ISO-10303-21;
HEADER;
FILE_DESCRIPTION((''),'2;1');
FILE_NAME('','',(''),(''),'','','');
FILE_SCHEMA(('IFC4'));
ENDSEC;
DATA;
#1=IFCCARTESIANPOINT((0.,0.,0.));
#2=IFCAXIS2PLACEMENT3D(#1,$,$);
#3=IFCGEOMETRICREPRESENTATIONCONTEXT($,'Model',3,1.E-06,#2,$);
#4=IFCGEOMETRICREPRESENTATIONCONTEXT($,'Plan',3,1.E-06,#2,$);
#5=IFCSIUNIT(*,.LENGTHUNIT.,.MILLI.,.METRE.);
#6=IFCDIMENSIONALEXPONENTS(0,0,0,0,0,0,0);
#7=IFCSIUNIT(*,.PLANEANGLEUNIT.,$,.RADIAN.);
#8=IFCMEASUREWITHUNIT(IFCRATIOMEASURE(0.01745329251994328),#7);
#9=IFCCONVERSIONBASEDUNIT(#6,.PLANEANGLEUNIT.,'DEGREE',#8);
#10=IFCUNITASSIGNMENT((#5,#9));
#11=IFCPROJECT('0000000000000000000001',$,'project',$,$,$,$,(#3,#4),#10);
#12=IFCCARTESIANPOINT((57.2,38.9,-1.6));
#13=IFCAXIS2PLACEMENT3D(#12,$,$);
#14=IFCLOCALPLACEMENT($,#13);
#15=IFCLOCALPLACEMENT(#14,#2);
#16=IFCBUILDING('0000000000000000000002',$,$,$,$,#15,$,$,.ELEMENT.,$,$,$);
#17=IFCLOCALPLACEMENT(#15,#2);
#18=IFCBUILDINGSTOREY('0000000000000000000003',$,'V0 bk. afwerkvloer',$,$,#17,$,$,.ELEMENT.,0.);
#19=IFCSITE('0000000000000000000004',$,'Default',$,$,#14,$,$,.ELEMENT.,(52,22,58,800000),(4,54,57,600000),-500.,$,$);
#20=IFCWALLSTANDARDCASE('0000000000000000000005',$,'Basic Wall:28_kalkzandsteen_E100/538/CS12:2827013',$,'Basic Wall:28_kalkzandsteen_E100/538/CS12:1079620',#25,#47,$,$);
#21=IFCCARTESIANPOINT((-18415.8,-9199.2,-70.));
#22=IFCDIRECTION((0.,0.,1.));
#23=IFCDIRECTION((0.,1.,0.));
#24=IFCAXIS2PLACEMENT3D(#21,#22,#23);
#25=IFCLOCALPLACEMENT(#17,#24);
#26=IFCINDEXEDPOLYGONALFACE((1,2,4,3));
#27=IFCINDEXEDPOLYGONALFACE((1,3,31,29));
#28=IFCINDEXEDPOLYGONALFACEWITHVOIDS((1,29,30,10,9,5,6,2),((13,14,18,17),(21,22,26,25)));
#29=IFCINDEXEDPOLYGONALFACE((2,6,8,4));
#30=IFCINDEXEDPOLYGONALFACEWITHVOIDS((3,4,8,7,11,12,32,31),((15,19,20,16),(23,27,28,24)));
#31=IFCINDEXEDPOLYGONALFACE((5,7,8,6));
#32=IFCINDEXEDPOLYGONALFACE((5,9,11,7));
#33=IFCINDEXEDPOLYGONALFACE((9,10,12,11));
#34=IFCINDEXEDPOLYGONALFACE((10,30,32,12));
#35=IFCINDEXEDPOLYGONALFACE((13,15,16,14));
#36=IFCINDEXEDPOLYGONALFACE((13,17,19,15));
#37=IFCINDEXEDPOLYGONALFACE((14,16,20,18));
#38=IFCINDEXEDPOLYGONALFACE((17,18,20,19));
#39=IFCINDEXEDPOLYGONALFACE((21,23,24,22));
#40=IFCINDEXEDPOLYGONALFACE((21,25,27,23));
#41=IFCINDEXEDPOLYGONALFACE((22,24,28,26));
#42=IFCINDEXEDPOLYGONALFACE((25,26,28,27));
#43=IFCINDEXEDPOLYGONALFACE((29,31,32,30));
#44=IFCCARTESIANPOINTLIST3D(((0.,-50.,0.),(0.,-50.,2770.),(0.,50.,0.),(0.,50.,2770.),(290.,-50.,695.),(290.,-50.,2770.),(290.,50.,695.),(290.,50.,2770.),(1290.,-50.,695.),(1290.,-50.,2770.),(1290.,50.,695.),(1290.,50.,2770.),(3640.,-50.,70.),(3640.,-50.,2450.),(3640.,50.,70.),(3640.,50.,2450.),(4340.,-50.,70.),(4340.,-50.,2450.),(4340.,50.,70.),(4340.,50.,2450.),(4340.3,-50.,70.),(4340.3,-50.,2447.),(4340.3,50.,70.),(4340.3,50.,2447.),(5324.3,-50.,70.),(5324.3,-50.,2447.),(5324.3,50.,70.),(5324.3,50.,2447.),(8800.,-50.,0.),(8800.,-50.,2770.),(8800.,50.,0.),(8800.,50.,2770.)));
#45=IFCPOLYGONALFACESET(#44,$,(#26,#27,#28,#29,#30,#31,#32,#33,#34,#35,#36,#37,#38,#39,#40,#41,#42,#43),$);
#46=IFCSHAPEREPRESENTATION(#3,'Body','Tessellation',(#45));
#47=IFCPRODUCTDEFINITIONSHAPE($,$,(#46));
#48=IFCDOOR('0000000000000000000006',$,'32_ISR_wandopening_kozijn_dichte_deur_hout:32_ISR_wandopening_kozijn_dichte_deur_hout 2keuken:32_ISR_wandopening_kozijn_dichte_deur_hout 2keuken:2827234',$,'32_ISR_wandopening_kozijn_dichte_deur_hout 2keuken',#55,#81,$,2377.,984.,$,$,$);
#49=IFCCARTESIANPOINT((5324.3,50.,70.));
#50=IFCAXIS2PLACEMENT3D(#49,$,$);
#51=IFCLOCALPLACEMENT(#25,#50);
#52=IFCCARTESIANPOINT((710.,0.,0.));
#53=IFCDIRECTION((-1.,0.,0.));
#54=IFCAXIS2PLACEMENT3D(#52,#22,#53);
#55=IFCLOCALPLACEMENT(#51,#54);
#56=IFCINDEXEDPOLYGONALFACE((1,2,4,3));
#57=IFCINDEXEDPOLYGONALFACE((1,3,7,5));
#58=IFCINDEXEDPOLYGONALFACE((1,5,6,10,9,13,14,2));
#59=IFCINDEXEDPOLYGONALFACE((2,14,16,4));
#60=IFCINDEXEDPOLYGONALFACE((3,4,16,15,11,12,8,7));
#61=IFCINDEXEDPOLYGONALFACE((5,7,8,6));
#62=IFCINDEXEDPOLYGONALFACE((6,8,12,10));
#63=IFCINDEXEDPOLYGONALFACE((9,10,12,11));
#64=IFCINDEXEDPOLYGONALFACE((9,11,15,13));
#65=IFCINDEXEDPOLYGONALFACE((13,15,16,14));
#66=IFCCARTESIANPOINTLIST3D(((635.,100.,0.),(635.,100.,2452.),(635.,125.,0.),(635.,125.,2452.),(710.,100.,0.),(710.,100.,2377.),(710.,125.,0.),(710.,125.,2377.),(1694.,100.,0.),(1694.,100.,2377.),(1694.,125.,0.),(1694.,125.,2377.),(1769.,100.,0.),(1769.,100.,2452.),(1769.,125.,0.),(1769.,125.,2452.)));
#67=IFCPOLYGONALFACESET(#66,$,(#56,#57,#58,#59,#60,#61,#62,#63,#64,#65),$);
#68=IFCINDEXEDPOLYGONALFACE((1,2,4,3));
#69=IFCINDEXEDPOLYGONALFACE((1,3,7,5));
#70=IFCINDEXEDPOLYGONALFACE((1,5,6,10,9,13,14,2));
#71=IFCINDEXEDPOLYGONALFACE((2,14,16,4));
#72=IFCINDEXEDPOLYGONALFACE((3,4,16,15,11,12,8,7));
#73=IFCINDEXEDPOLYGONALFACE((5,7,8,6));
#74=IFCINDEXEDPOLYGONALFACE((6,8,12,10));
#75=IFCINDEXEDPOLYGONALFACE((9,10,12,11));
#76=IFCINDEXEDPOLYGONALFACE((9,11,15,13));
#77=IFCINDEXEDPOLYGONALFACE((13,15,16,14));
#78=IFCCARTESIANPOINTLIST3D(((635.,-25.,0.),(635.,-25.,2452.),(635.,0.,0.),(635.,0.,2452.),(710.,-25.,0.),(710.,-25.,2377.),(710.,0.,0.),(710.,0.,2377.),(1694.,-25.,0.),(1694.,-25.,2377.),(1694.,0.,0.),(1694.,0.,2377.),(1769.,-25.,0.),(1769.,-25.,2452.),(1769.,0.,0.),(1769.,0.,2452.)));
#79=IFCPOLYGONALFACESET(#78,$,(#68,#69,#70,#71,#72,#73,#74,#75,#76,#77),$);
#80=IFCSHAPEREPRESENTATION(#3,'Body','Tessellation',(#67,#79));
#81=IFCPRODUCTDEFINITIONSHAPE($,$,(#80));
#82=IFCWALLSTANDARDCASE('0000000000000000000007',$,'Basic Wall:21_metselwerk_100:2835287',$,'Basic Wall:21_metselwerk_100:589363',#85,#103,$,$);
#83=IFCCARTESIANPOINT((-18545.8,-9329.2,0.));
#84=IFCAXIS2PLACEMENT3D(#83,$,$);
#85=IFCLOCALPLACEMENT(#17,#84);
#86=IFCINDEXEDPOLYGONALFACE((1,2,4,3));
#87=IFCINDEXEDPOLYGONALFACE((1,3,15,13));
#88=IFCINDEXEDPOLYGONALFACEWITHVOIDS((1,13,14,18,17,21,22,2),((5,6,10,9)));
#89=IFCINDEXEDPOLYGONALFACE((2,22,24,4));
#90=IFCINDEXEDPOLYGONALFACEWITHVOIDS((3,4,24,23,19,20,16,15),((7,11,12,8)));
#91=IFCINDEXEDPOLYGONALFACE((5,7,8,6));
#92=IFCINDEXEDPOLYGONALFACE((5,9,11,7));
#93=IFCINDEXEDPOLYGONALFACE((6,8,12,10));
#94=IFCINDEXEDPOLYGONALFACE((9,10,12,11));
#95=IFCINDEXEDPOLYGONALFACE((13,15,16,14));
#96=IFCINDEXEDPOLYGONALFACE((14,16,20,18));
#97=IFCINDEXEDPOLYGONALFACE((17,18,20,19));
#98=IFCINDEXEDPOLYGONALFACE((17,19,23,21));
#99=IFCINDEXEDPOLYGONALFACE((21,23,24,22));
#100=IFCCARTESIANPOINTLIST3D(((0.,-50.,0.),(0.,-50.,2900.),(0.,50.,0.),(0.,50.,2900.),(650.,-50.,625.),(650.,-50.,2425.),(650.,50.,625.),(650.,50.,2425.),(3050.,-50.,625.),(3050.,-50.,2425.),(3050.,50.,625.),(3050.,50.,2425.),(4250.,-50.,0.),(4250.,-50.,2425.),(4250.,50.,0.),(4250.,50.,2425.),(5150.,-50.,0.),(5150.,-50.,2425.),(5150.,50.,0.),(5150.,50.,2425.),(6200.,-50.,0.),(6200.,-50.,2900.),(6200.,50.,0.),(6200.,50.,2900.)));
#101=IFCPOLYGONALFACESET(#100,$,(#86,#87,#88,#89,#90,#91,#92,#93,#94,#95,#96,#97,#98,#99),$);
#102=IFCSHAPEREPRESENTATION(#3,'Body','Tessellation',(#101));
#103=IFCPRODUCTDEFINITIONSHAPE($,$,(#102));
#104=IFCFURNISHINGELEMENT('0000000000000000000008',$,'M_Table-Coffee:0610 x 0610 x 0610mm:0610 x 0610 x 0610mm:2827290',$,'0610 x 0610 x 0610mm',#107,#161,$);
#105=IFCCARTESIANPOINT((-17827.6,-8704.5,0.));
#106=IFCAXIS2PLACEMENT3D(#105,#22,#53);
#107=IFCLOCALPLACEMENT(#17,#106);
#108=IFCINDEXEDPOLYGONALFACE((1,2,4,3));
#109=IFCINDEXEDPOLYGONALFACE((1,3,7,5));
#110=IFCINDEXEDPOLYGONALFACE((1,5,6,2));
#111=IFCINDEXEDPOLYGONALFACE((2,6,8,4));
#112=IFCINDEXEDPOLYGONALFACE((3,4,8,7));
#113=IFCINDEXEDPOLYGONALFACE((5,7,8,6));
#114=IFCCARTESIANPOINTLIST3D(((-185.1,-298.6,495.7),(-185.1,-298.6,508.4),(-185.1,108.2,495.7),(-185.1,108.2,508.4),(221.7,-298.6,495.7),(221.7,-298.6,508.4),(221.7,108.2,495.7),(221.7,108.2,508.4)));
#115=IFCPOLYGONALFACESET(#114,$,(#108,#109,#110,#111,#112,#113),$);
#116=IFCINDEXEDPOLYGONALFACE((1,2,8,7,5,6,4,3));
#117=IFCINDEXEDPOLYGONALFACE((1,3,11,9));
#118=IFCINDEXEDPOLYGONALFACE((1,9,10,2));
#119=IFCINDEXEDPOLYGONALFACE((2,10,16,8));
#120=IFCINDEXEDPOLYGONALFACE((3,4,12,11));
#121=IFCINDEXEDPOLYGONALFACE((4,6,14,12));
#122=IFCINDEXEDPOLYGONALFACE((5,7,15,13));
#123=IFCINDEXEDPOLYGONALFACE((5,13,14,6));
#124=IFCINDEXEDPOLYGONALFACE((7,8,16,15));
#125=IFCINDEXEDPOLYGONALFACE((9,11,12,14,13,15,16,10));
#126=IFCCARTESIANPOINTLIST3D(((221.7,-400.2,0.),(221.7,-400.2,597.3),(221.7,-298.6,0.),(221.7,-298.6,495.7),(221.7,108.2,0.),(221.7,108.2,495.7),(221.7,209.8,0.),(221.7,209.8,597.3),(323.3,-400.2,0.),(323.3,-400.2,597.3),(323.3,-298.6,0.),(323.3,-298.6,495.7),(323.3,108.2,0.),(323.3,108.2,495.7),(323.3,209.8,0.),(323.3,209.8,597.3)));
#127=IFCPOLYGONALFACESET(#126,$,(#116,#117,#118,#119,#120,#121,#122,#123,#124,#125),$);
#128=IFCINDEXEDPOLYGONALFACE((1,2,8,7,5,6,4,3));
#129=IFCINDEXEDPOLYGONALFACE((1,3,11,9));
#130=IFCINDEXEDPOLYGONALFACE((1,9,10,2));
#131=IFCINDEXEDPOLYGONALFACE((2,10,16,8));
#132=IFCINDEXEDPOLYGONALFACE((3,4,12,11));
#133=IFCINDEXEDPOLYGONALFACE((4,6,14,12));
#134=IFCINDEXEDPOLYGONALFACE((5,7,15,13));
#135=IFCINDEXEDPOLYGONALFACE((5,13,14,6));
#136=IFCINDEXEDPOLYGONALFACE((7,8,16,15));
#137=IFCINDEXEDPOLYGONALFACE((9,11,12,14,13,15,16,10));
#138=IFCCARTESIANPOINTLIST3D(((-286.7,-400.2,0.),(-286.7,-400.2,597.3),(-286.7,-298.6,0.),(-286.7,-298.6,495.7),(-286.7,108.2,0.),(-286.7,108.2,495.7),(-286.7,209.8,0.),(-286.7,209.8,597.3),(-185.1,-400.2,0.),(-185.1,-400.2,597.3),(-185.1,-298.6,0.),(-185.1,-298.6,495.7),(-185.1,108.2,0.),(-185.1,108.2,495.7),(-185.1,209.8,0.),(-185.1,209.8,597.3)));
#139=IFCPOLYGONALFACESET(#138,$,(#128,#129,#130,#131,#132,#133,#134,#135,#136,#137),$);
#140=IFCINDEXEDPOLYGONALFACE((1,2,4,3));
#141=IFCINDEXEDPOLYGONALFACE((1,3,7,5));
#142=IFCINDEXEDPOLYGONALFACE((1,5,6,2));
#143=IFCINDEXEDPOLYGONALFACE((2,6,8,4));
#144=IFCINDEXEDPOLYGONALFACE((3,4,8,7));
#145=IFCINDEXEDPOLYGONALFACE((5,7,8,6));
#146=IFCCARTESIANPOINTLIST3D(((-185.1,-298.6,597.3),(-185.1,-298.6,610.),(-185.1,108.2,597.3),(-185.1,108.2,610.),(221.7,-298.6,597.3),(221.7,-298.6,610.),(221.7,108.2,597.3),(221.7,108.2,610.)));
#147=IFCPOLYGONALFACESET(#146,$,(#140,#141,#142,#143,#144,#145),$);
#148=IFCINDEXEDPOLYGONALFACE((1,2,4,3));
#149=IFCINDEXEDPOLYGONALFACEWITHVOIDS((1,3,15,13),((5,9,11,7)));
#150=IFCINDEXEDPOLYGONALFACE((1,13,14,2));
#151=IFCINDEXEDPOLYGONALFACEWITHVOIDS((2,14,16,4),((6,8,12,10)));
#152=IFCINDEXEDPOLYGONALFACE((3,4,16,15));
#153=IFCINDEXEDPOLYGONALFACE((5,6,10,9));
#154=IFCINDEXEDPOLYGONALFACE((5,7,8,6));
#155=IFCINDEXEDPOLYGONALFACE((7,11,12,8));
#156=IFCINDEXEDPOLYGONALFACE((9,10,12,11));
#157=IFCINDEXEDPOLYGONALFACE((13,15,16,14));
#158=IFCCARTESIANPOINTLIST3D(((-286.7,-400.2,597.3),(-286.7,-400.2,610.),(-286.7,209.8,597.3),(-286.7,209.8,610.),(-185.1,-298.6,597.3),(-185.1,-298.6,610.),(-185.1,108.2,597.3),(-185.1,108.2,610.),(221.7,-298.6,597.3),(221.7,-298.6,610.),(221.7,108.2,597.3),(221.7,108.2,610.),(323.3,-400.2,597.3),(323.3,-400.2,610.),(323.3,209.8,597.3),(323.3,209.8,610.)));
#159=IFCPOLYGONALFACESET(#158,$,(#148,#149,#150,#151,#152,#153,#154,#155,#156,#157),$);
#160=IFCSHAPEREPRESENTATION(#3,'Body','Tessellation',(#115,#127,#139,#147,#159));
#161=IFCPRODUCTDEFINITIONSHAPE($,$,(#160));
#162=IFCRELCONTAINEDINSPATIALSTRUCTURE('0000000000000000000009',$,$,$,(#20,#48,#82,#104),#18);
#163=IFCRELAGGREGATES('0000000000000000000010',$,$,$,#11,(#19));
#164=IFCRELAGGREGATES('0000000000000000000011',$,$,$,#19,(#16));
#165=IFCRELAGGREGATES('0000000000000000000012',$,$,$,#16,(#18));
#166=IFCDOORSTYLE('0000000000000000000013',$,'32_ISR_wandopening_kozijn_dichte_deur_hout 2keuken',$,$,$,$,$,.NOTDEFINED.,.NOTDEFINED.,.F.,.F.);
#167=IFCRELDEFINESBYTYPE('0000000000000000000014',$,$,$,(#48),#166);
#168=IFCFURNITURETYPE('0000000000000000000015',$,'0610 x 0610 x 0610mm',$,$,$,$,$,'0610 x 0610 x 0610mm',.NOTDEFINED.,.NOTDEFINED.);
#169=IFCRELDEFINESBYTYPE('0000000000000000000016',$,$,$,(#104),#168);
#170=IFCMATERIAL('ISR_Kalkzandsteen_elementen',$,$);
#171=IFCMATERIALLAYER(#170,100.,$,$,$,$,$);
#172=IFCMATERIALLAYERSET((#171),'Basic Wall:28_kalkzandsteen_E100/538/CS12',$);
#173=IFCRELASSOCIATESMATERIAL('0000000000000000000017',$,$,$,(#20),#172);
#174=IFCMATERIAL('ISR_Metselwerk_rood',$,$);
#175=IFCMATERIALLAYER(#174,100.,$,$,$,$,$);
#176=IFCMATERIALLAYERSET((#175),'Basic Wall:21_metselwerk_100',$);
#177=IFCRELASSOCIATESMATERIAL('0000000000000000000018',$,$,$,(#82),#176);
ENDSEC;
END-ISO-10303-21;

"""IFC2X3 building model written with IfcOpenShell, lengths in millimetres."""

from ifc_helpers import new_model, entity, si_unit, converted_unit, frame, frame_2d, origin, origin_2d_with_axis, place, context, project, spatial, polyline, rectangle, outline, extrude, source, transform, mapped, material, layer, layer_set, layer_usage, type_object, type_shapes, element, fill, save


model = new_model("IFC2X3")

# Units and contexts
model_context = context("Model", 3, precision=1e-06, world=origin())
plan_context = context("Plan", 3, precision=1e-06, world=origin())
ifc_project = project(units=[si_unit("LENGTHUNIT", "METRE", prefix="MILLI"), converted_unit("PLANEANGLEUNIT", "DEGREE", entity("IfcRatioMeasure", 0.01745329251994328), si_unit("PLANEANGLEUNIT", "RADIAN"), dimensions=[0, 0, 0, 0, 0, 0, 0])], contexts=[model_context, plan_context])

# Site, building, storey
site_placement = place(None, frame((57.2, 38.9, -1.6)))
site = spatial("IfcSite", under=ifc_project, at=site_placement, Name="Default", CompositionType="ELEMENT", RefLatitude=(52, 22, 58, 800000), RefLongitude=(4, 54, 57, 600000), RefElevation=-500.0)
building_placement = place(site_placement, origin())
building = spatial("IfcBuilding", under=site, at=building_placement, CompositionType="ELEMENT")
storey_placement = place(building_placement, origin())
storey = spatial("IfcBuildingStorey", under=building, at=storey_placement, Name="V0 bk. afwerkvloer", CompositionType="ELEMENT", Elevation=0.0)

# Wall, openings, door
ifc_material_1 = material(Name="ISR_Kalkzandsteen_elementen")
ifc_layer_1 = layer(ifc_material_1, 100.0)
ifc_layer_set_1 = layer_set([ifc_layer_1], Name="Basic Wall:28_kalkzandsteen_E100/538/CS12")
ifc_layer_usage_1 = layer_usage(ifc_layer_set_1, "AXIS2", "POSITIVE", -50.0)
wall_1_placement = place(storey_placement, frame((-18415.8, -9199.2, -70.0), z_axis=(0.0, 0.0, 1.0), x_axis=(0.0, 1.0, 0.0)))
wall_1 = element("IfcWallStandardCase", 1, at=wall_1_placement, inside=storey, material=ifc_layer_usage_1, Name="Basic Wall:28_kalkzandsteen_E100/538/CS12:2827013", ObjectType="Basic Wall:28_kalkzandsteen_E100/538/CS12:1079620", context=model_context, shape_type="SweptSolid", body=[
    extrude(rectangle(XDim=8800.0, YDim=100.0, at=frame_2d((4400.0, 0.0), x_axis=(-1.0, 0.0))), origin(), (0.0, 0.0, 1.0), 2770.0),
])
opening_1_placement = place(wall_1_placement, origin())
element("IfcOpeningElement", 2, at=opening_1_placement, cuts=wall_1, ObjectType="Opening", context=model_context, shape_type="SweptSolid", body=[
    extrude(rectangle(XDim=2075.0, YDim=1000.0, at=frame_2d((0.0, 0.0), x_axis=(0.0, 1.0))), frame((790.0, -202.4, 1732.5), z_axis=(0.0, 1.0, 0.0), x_axis=(-1.0, 0.0, 0.0)), (0.0, 0.0, 1.0), 404.8),
])
opening_2_placement = place(wall_1_placement, origin())
element("IfcOpeningElement", 3, at=opening_2_placement, cuts=wall_1, ObjectType="Opening", context=model_context, shape_type="SweptSolid", body=[
    extrude(rectangle(XDim=2380.0, YDim=700.0, at=origin_2d_with_axis()), frame((3990.0, -202.4, 1260.0), z_axis=(0.0, 1.0, 0.0), x_axis=(0.0, 0.0, 1.0)), (0.0, 0.0, 1.0), 404.8),
])
opening_3_placement = place(wall_1_placement, frame((5324.3, 50.0, 70.0)))
opening_3 = element("IfcOpeningElement", 4, at=opening_3_placement, cuts=wall_1, ObjectType="Opening", context=model_context, shape_type="SweptSolid", body=[
    extrude(rectangle(XDim=2377.0, YDim=984.0, at=frame_2d((1188.5, 492.0), x_axis=(1.0, 0.0))), frame((0.0, 0.0, 0.0), z_axis=(0.0, -1.0, 0.0), x_axis=(0.0, 0.0, 1.0)), (0.0, 0.0, 1.0), 100.0),
])
door_style_1 = type_object("IfcDoorStyle", Name="32_ISR_wandopening_kozijn_dichte_deur_hout 2keuken", ConstructionType="NOTDEFINED", OperationType="NOTDEFINED", ParameterTakesPrecedence=False, Sizeable=False)
shared_shape_1 = source(origin(), model_context, "Body", "SweptSolid", [
    extrude(outline(polyline([(-1169.7, 492.0), (1207.2, 492.0), (1207.2, 567.0), (-1244.7, 567.0), (-1244.7, -567.0), (1207.2, -567.0), (1207.2, -492.0), (-1169.7, -492.0), (-1169.7, 492.0)])), frame((1202.0, 125.0, 1207.2), z_axis=(0.0, -1.0, 0.0), x_axis=(0.0, 0.0, -1.0)), (0.0, 0.0, 1.0), 25.0),
    extrude(outline(polyline([(-567.0, -1244.7), (567.0, -1244.7), (567.0, 1207.2), (492.0, 1207.2), (492.0, -1169.7), (-492.0, -1169.7), (-492.0, 1207.2), (-567.0, 1207.2), (-567.0, -1244.7)])), frame((1202.0, 0.0, 1207.2), z_axis=(0.0, -1.0, 0.0), x_axis=(-1.0, 0.0, 0.0)), (0.0, 0.0, 1.0), 25.0),
])
type_shapes(door_style_1, [shared_shape_1])
door_1_placement = place(opening_3_placement, frame((710.0, 0.0, 0.0), z_axis=(0.0, 0.0, 1.0), x_axis=(-1.0, 0.0, 0.0)))
door_1 = element("IfcDoor", 5, at=door_1_placement, inside=storey, type_object=door_style_1, Name="32_ISR_wandopening_kozijn_dichte_deur_hout:32_ISR_wandopening_kozijn_dichte_deur_hout 2keuken:32_ISR_wandopening_kozijn_dichte_deur_hout 2keuken:2827234", ObjectType="32_ISR_wandopening_kozijn_dichte_deur_hout 2keuken", OverallHeight=2377.0, OverallWidth=984.0, context=model_context, shape_type="MappedRepresentation", body=[
    mapped(shared_shape_1, transform((0.0, 0.0, 0.0), scale=1.0)),
])
fill(opening_3, door_1)

# Wall, openings
ifc_material_2 = material(Name="ISR_Metselwerk_rood")
ifc_layer_2 = layer(ifc_material_2, 100.0)
ifc_layer_set_2 = layer_set([ifc_layer_2], Name="Basic Wall:21_metselwerk_100")
ifc_layer_usage_2 = layer_usage(ifc_layer_set_2, "AXIS2", "POSITIVE", -50.0)
wall_2_placement = place(storey_placement, frame((-18545.8, -9329.2, 0.0)))
wall_2 = element("IfcWallStandardCase", 6, at=wall_2_placement, inside=storey, material=ifc_layer_usage_2, Name="Basic Wall:21_metselwerk_100:2835287", ObjectType="Basic Wall:21_metselwerk_100:589363", context=model_context, shape_type="SweptSolid", body=[
    extrude(rectangle(XDim=6200.0, YDim=100.0, at=frame_2d((3100.0, 0.0), x_axis=(-1.0, 0.0))), origin(), (0.0, 0.0, 1.0), 2900.0),
])
opening_4_placement = place(wall_2_placement, origin())
element("IfcOpeningElement", 7, at=opening_4_placement, cuts=wall_2, ObjectType="Opening", context=model_context, shape_type="SweptSolid", body=[
    extrude(rectangle(XDim=2425.0, YDim=900.0, at=frame_2d((0.0, 0.0), x_axis=(0.0, 1.0))), frame((4700.0, -202.4, 1212.5), z_axis=(0.0, 1.0, 0.0), x_axis=(-1.0, 0.0, 0.0)), (0.0, 0.0, 1.0), 404.8),
])
opening_5_placement = place(wall_2_placement, origin())
element("IfcOpeningElement", 8, at=opening_5_placement, cuts=wall_2, ObjectType="Opening", context=model_context, shape_type="SweptSolid", body=[
    extrude(rectangle(XDim=1800.0, YDim=2400.0, at=frame_2d((0.0, 0.0), x_axis=(0.0, 1.0))), frame((1850.0, -202.4, 1525.0), z_axis=(0.0, 1.0, 0.0), x_axis=(-1.0, 0.0, 0.0)), (0.0, 0.0, 1.0), 404.8),
])

# Furnishing element
furniture_type = type_object("IfcFurnitureType", Name="0610 x 0610 x 0610mm", ElementType="0610 x 0610 x 0610mm", AssemblyPlace="NOTDEFINED")
shared_shape_2 = source(origin(), model_context, "Body", "SweptSolid", [
    extrude(rectangle(XDim=406.8, YDim=406.8, at=origin_2d_with_axis()), frame((18.3, -95.2, 495.7), z_axis=(0.0, 0.0, 1.0), x_axis=(0.0, 1.0, 0.0)), (0.0, 0.0, 1.0), 12.7),
    extrude(outline(polyline([(-305.0, -273.2), (-203.4, -273.2), (-203.4, 222.5), (203.4, 222.5), (203.4, -273.2), (305.0, -273.2), (305.0, 324.0), (-305.0, 324.0), (-305.0, -273.2)])), frame((221.7, -95.2, 273.2), z_axis=(1.0, 0.0, 0.0), x_axis=(0.0, 1.0, 0.0)), (0.0, 0.0, 1.0), 101.6),
    extrude(outline(polyline([(-324.1, -305.0), (273.3, -305.0), (273.3, -203.4), (-222.4, -203.4), (-222.4, 203.4), (273.3, 203.4), (273.3, 305.0), (-324.1, 305.0), (-324.1, -305.0)])), frame((-286.7, -95.2, 273.3), z_axis=(1.0, 0.0, 0.0), x_axis=(0.0, 0.0, -1.0)), (0.0, 0.0, 1.0), 101.6),
    extrude(rectangle(XDim=406.8, YDim=406.8, at=origin_2d_with_axis()), frame((18.3, -95.2, 597.3), z_axis=(0.0, 0.0, 1.0), x_axis=(0.0, 1.0, 0.0)), (0.0, 0.0, 1.0), 12.7),
    extrude(outline(polyline([(-305.0, -305.0), (305.0, -305.0), (305.0, 305.0), (-305.0, 305.0), (-305.0, -305.0)]), holes=[polyline([(-203.4, -203.4), (-203.4, 203.4), (203.4, 203.4), (203.4, -203.4), (-203.4, -203.4)])]), frame((18.3, -95.2, 597.3), z_axis=(0.0, 0.0, 1.0), x_axis=(0.0, 1.0, 0.0)), (0.0, 0.0, 1.0), 12.7),
])
type_shapes(furniture_type, [shared_shape_2])
furnishing_placement = place(storey_placement, frame((-17827.6, -8704.5, 0.0), z_axis=(0.0, 0.0, 1.0), x_axis=(-1.0, 0.0, 0.0)))
element("IfcFurnishingElement", 9, at=furnishing_placement, inside=storey, type_object=furniture_type, Name="M_Table-Coffee:0610 x 0610 x 0610mm:0610 x 0610 x 0610mm:2827290", ObjectType="0610 x 0610 x 0610mm", context=model_context, shape_type="MappedRepresentation", body=[
    mapped(shared_shape_2, transform((0.0, 0.0, 0.0), scale=1.0)),
])

save(model, "model.ifc")
